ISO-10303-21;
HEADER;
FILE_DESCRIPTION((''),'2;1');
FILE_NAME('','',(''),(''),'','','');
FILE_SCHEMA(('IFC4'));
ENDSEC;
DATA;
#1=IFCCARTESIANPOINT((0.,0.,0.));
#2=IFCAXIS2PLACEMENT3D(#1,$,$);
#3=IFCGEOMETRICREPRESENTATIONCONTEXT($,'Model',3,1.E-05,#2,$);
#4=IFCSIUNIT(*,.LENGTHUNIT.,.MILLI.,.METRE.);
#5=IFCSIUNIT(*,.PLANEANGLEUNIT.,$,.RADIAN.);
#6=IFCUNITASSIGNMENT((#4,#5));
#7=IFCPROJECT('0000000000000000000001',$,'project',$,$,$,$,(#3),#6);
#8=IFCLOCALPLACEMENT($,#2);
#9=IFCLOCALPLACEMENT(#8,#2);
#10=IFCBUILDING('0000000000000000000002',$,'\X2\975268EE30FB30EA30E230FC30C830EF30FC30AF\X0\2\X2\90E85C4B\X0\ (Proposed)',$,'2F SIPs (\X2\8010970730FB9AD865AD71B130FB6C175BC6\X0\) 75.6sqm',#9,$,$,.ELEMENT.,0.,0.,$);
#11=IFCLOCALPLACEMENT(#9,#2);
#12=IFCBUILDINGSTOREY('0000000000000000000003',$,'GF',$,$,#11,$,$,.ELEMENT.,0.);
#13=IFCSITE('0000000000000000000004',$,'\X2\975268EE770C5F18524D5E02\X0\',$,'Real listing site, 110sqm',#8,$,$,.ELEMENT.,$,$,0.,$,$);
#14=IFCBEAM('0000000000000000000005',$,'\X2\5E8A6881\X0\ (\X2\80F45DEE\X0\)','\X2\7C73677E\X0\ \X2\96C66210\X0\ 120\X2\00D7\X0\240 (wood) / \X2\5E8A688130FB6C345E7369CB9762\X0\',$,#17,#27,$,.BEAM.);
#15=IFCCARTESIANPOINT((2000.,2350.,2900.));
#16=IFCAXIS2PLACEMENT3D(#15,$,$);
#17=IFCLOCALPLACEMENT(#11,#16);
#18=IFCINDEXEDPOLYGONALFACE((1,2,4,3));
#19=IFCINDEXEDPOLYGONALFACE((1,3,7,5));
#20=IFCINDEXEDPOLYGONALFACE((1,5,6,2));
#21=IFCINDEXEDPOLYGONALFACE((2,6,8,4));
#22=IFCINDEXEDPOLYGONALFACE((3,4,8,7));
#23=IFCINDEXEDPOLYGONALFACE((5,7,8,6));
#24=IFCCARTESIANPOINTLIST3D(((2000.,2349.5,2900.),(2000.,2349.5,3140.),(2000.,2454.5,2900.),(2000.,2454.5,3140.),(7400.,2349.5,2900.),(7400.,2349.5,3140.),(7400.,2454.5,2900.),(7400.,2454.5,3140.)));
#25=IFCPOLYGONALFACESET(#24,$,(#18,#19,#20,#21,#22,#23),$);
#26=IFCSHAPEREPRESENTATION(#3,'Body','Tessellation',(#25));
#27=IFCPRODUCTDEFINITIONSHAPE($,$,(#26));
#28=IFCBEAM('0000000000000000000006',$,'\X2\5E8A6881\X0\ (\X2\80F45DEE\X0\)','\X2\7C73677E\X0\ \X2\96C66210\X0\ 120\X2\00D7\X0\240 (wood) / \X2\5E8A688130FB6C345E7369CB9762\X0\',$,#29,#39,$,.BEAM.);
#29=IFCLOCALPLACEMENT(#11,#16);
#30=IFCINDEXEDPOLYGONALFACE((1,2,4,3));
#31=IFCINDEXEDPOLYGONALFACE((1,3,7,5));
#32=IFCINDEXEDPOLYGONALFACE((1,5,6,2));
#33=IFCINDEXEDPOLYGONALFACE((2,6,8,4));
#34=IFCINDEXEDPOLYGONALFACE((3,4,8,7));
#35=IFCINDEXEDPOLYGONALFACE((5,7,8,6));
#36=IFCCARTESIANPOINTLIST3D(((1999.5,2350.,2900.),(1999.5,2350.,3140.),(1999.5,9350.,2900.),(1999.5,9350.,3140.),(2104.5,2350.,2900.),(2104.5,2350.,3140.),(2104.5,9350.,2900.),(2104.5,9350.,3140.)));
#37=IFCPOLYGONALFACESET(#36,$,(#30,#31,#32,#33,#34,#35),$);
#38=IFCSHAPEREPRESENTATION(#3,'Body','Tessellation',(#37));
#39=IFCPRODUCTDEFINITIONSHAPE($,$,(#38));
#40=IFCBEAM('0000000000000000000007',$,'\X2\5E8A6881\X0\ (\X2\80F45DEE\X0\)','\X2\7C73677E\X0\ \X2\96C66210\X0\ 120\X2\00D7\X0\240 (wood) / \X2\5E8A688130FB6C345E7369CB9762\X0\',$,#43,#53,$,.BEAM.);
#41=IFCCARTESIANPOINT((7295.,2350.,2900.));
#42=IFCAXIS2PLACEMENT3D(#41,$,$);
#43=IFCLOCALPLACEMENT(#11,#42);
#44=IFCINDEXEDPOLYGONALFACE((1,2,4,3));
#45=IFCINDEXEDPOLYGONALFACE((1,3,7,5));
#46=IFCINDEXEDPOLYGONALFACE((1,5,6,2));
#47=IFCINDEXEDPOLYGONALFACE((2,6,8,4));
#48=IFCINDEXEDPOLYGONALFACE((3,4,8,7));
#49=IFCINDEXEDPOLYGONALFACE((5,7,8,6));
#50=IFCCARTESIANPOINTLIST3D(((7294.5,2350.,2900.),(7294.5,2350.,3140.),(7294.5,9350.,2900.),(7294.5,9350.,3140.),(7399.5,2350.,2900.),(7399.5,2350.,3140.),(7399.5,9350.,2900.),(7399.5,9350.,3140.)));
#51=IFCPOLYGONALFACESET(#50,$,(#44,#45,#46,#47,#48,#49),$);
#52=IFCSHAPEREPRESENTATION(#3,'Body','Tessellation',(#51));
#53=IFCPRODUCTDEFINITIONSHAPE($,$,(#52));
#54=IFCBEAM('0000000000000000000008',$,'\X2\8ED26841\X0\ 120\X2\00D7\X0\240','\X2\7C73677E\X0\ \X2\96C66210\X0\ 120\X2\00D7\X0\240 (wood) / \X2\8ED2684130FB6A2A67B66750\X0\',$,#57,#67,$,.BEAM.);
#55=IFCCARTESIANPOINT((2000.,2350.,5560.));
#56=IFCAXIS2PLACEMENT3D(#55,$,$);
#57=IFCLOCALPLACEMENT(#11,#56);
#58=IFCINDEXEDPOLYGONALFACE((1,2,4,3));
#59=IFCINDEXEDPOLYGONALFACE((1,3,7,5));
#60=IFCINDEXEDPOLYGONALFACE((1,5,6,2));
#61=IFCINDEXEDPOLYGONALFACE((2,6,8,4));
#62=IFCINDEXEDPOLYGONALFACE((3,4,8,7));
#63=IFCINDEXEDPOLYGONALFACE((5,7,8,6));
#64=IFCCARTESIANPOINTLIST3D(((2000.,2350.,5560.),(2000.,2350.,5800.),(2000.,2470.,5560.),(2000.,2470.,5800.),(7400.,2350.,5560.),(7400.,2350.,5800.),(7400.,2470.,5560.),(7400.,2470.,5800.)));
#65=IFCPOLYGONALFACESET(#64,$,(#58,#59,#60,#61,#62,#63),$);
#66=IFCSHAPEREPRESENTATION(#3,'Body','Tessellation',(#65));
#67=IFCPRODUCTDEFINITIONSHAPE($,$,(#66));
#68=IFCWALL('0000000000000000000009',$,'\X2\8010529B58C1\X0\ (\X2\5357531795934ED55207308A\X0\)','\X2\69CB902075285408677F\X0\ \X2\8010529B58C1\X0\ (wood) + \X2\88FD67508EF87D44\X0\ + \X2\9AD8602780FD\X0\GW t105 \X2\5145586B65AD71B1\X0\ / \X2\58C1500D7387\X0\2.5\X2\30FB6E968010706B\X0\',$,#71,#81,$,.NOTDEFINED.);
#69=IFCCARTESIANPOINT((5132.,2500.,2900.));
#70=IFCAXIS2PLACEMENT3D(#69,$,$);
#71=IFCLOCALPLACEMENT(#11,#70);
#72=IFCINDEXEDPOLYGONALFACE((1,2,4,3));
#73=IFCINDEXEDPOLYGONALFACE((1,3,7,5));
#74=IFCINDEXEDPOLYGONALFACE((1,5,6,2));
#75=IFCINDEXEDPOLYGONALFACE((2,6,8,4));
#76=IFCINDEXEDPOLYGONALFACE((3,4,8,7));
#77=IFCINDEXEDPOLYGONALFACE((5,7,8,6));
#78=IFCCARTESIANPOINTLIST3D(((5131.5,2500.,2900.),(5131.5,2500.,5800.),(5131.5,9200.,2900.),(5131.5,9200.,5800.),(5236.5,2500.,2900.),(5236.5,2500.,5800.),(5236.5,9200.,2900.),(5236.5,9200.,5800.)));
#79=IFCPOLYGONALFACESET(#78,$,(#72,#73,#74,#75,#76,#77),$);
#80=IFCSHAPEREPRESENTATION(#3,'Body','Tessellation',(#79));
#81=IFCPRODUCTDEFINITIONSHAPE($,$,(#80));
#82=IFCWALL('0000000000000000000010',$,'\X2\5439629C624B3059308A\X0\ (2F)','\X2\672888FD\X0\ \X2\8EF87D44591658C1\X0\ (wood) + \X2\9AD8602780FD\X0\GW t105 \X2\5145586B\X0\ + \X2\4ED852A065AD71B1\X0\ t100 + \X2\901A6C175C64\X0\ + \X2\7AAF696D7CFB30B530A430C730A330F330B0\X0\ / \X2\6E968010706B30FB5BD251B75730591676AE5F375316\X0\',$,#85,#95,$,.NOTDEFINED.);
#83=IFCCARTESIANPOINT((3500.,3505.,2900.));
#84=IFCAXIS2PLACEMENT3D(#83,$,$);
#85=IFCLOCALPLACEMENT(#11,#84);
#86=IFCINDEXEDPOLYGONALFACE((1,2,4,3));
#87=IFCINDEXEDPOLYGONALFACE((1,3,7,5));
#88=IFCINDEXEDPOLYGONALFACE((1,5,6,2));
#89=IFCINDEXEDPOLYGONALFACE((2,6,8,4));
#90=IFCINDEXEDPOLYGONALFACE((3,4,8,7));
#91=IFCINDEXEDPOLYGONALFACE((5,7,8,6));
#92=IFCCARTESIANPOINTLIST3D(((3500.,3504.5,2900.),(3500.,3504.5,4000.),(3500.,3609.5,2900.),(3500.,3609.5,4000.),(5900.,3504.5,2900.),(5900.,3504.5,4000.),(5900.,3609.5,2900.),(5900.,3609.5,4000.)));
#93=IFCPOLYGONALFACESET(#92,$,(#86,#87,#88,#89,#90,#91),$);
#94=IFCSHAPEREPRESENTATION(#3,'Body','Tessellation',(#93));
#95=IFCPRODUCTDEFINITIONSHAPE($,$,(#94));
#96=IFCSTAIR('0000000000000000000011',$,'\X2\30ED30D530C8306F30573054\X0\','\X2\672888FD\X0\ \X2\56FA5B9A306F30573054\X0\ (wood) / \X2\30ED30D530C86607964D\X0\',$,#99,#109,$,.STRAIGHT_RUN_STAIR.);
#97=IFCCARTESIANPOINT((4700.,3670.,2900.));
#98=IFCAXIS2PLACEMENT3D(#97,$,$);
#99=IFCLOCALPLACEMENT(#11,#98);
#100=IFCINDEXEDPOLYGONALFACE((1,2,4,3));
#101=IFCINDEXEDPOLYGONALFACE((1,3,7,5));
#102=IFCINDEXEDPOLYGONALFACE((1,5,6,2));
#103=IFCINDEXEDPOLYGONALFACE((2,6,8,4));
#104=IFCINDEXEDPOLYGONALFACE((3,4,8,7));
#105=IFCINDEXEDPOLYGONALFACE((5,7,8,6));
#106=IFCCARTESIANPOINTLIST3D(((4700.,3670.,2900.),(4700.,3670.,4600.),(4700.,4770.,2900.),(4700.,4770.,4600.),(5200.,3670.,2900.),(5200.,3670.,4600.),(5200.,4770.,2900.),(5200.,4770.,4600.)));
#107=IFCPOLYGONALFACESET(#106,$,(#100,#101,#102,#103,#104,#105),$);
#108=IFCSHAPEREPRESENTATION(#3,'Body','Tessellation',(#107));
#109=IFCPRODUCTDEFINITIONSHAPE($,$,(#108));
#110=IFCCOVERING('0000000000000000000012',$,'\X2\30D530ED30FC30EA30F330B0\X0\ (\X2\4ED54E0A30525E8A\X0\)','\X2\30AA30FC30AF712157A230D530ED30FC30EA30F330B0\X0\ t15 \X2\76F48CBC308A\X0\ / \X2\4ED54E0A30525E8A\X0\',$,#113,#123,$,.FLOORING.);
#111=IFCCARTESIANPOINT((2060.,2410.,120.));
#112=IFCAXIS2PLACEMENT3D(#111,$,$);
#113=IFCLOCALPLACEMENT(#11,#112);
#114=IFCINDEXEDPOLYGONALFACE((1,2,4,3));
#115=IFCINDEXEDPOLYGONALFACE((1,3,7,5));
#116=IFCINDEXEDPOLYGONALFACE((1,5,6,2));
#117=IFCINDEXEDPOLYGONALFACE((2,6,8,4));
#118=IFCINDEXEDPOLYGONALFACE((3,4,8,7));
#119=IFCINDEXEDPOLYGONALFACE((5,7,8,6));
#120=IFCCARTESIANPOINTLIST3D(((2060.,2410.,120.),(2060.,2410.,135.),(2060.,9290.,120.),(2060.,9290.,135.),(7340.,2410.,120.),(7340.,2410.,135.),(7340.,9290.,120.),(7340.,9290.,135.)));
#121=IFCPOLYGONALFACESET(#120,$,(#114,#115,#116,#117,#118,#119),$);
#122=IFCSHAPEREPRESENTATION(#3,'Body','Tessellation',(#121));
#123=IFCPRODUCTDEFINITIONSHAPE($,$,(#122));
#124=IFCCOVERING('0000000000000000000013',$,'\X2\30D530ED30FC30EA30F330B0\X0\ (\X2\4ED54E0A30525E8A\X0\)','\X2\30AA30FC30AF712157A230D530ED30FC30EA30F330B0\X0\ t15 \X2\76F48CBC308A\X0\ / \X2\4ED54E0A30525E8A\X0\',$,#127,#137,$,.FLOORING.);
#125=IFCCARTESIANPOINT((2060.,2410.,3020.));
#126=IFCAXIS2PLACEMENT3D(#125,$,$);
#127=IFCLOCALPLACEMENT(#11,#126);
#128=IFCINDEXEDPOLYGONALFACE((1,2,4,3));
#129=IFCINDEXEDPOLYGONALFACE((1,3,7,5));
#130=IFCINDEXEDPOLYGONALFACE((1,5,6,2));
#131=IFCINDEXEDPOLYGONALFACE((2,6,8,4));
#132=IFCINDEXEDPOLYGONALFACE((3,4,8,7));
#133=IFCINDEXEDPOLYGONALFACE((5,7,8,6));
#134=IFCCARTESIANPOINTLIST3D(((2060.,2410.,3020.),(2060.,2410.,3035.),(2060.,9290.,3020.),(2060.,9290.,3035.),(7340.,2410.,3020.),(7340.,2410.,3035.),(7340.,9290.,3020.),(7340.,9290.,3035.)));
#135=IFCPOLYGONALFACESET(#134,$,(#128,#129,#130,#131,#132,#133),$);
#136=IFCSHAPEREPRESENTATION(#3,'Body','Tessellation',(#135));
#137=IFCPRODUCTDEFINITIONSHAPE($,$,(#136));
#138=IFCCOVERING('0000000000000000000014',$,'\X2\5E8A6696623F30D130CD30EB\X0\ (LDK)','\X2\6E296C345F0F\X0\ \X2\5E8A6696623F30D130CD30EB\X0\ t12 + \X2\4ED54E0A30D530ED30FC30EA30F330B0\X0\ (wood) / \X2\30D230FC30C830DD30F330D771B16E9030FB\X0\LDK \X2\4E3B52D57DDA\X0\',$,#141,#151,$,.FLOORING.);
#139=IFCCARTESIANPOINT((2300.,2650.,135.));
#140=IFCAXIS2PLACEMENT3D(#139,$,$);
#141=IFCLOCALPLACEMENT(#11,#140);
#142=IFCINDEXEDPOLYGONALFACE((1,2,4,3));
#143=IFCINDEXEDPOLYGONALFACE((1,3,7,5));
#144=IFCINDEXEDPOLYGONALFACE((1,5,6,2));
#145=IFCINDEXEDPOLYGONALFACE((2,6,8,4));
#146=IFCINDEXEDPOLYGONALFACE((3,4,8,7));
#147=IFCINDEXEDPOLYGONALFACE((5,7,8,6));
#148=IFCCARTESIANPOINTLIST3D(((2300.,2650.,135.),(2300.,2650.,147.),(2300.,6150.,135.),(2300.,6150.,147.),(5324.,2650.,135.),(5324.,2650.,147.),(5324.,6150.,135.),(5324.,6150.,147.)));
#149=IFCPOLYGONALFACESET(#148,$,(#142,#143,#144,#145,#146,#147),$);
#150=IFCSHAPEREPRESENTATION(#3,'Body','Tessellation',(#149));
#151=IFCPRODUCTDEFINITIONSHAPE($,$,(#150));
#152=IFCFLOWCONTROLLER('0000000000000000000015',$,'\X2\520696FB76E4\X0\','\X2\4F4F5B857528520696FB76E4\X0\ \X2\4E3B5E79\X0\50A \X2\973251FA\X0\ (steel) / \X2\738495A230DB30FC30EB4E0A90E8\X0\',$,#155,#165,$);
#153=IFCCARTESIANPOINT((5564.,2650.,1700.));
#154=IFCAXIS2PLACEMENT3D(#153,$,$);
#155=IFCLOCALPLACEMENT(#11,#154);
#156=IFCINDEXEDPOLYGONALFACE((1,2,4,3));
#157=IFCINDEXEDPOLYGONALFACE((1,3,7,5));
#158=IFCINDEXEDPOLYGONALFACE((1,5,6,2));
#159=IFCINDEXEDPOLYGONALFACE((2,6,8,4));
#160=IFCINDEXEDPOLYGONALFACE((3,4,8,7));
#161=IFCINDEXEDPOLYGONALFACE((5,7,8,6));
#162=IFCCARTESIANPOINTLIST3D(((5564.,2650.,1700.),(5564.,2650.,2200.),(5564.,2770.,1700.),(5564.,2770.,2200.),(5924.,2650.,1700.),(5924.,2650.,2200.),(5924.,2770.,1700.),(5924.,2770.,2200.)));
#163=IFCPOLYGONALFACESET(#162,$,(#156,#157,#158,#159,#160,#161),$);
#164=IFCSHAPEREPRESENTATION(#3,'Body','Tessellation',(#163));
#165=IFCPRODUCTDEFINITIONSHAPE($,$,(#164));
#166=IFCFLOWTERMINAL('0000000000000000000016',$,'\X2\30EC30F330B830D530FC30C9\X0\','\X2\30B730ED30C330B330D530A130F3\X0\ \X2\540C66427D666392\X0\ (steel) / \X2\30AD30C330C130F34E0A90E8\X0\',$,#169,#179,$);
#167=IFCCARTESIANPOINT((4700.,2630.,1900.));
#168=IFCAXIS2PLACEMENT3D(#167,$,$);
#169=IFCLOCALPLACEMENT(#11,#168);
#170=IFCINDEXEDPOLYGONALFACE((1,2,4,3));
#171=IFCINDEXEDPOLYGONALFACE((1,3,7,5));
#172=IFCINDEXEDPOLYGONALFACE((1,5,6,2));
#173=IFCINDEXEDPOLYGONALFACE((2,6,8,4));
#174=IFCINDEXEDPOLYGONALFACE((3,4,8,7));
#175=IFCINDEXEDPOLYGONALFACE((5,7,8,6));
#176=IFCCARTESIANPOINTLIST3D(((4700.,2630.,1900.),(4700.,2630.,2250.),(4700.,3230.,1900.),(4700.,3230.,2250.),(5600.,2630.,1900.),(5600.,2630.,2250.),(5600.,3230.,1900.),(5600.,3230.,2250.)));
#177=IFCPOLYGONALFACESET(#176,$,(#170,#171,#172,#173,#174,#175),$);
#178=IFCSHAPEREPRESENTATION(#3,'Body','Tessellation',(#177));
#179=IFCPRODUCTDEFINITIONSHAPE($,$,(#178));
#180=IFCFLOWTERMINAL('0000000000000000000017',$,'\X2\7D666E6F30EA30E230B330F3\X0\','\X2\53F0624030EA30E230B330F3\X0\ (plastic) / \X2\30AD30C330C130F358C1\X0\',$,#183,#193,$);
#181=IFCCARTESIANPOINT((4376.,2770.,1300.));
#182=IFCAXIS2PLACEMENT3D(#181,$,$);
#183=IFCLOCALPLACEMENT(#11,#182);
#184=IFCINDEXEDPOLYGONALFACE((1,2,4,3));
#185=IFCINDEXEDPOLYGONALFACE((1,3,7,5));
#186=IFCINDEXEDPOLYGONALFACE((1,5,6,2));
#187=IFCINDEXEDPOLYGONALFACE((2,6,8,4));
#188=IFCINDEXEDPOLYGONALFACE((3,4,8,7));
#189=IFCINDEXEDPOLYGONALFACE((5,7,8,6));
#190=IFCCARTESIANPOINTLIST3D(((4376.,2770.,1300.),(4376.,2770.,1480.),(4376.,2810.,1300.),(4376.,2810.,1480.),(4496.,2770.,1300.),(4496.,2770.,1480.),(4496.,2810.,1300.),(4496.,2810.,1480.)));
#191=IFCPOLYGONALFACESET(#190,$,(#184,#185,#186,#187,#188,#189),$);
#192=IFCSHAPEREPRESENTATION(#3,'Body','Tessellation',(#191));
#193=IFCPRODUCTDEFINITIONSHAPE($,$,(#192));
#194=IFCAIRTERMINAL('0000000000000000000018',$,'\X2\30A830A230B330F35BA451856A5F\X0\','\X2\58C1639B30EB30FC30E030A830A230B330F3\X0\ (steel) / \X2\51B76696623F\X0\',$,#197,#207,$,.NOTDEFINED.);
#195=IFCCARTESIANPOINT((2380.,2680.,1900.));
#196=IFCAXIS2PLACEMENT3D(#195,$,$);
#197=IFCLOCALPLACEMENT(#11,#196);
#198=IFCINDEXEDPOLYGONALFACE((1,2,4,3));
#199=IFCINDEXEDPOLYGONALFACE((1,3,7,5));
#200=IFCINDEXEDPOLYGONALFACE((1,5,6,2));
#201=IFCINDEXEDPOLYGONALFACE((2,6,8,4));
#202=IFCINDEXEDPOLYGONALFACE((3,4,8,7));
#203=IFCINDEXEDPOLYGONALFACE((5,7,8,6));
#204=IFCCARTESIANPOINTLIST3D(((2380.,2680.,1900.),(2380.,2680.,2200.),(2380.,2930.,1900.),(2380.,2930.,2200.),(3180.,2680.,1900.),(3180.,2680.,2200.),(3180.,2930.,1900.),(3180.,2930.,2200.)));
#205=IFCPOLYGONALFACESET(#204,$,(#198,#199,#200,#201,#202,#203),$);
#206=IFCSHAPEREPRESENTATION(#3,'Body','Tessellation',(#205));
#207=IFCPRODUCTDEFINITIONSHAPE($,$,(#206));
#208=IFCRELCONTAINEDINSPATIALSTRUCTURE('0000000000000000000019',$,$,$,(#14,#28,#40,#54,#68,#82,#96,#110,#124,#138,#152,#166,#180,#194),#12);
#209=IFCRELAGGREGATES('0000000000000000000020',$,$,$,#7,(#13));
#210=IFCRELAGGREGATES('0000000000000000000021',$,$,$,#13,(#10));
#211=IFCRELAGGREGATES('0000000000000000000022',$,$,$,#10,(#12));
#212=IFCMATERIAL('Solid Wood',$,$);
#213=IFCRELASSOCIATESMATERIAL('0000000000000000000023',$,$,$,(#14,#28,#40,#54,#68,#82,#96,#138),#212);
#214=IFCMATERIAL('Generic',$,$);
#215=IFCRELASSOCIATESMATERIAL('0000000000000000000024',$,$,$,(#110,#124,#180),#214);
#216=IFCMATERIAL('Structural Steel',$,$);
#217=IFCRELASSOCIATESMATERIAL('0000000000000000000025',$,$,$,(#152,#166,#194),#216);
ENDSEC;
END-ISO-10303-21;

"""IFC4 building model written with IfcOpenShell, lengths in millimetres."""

from ifc_helpers import new_model, si_unit, frame, frame_2d, origin, place, context, project, spatial, rectangle, extrude, material, element, save


model = new_model("IFC4")

# Units and contexts
model_context = context("Model", 3, precision=1e-05, world=origin())
ifc_project = project(units=[si_unit("LENGTHUNIT", "METRE", prefix="MILLI"), si_unit("PLANEANGLEUNIT", "RADIAN")], contexts=[model_context])

# Site, building, storey
site_placement = place(None, origin())
site = spatial("IfcSite", under=ifc_project, at=site_placement, Name="青森県弘前市", ObjectType="Real listing site, 110sqm", CompositionType="ELEMENT", RefElevation=0.0)
building_placement = place(site_placement, origin())
building = spatial("IfcBuilding", under=site, at=building_placement, Name="青森・リモートワーク2部屋 (Proposed)", ObjectType="2F SIPs (耐震・高断熱・気密) 75.6sqm", CompositionType="ELEMENT", ElevationOfRefHeight=0.0, ElevationOfTerrain=0.0)
storey_placement = place(building_placement, origin())
storey = spatial("IfcBuildingStorey", under=building, at=storey_placement, Name="GF", CompositionType="ELEMENT", Elevation=0.0)

# Beams
ifc_material_1 = material(Name="Solid Wood")
beam_1_placement = place(storey_placement, frame((2000.0, 2350.0, 2900.0)))
element("IfcBeam", 1, at=beam_1_placement, inside=storey, material=ifc_material_1, Name="床梁 (胴差)", Description="米松 集成 120×240 (wood) / 床梁・水平構面", PredefinedType="BEAM", context=model_context, shape_type="SweptSolid", body=[
    extrude(rectangle(XDim=5400.0, YDim=105.0, at=frame_2d((2700.0, 52.0))), frame((2000.0, 2350.0, 2900.0)), (0.0, 0.0, 1.0), 240.0),
])
beam_2_placement = place(storey_placement, frame((2000.0, 2350.0, 2900.0)))
element("IfcBeam", 2, at=beam_2_placement, inside=storey, material=ifc_material_1, Name="床梁 (胴差)", Description="米松 集成 120×240 (wood) / 床梁・水平構面", PredefinedType="BEAM", context=model_context, shape_type="SweptSolid", body=[
    extrude(rectangle(XDim=105.0, YDim=7000.0, at=frame_2d((52.0, 3500.0))), frame((2000.0, 2350.0, 2900.0)), (0.0, 0.0, 1.0), 240.0),
])
beam_3_placement = place(storey_placement, frame((7295.0, 2350.0, 2900.0)))
element("IfcBeam", 3, at=beam_3_placement, inside=storey, material=ifc_material_1, Name="床梁 (胴差)", Description="米松 集成 120×240 (wood) / 床梁・水平構面", PredefinedType="BEAM", context=model_context, shape_type="SweptSolid", body=[
    extrude(rectangle(XDim=105.0, YDim=7000.0, at=frame_2d((52.0, 3500.0))), frame((7295.0, 2350.0, 2900.0)), (0.0, 0.0, 1.0), 240.0),
])
beam_4_placement = place(storey_placement, frame((2000.0, 2350.0, 5560.0)))
element("IfcBeam", 4, at=beam_4_placement, inside=storey, material=ifc_material_1, Name="軒桁 120×240", Description="米松 集成 120×240 (wood) / 軒桁・横架材", PredefinedType="BEAM", context=model_context, shape_type="SweptSolid", body=[
    extrude(rectangle(XDim=5400.0, YDim=120.0, at=frame_2d((2700.0, 60.0))), frame((2000.0, 2350.0, 5560.0)), (0.0, 0.0, 1.0), 240.0),
])

# Walls
wall_1_placement = place(storey_placement, frame((5132.0, 2500.0, 2900.0)))
element("IfcWall", 5, at=wall_1_placement, inside=storey, material=ifc_material_1, Name="耐力壁 (南北間仕切り)", Description="構造用合板 耐力壁 (wood) + 製材軸組 + 高性能GW t105 充填断熱 / 壁倍率2.5・準耐火", PredefinedType="NOTDEFINED", context=model_context, shape_type="SweptSolid", body=[
    extrude(rectangle(XDim=105.0, YDim=6700.0, at=frame_2d((52.0, 3350.0))), frame((5132.0, 2500.0, 2900.0)), (0.0, 0.0, 1.0), 2900.0),
])
wall_2_placement = place(storey_placement, frame((3500.0, 3505.0, 2900.0)))
element("IfcWall", 6, at=wall_2_placement, inside=storey, material=ifc_material_1, Name="吹抜手すり (2F)", Description="木製 軸組外壁 (wood) + 高性能GW t105 充填 + 付加断熱 t100 + 通気層 + 窯業系サイディング / 準耐火・寒冷地外皮強化", PredefinedType="NOTDEFINED", context=model_context, shape_type="SweptSolid", body=[
    extrude(rectangle(XDim=2400.0, YDim=105.0, at=frame_2d((1200.0, 52.0))), frame((3500.0, 3505.0, 2900.0)), (0.0, 0.0, 1.0), 1100.0),
])

# Stair
stair_1_placement = place(storey_placement, frame((4700.0, 3670.0, 2900.0)))
element("IfcStair", 7, at=stair_1_placement, inside=storey, material=ifc_material_1, Name="ロフトはしご", Description="木製 固定はしご (wood) / ロフト昇降", PredefinedType="STRAIGHT_RUN_STAIR", context=model_context, shape_type="SweptSolid", body=[
    extrude(rectangle(XDim=500.0, YDim=1100.0, at=frame_2d((250.0, 550.0))), frame((4700.0, 3670.0, 2900.0)), (0.0, 0.0, 1.0), 1700.0),
])

# Coverings
ifc_material_2 = material(Name="Generic")
covering_1_placement = place(storey_placement, frame((2060.0, 2410.0, 120.0)))
element("IfcCovering", 8, at=covering_1_placement, inside=storey, material=ifc_material_2, Name="フローリング (仕上げ床)", Description="オーク無垢フローリング t15 直貼り / 仕上げ床", PredefinedType="FLOORING", context=model_context, shape_type="SweptSolid", body=[
    extrude(rectangle(XDim=5280.0, YDim=6880.0, at=frame_2d((2640.0, 3440.0))), frame((2060.0, 2410.0, 120.0)), (0.0, 0.0, 1.0), 15.0),
])
covering_2_placement = place(storey_placement, frame((2060.0, 2410.0, 3020.0)))
element("IfcCovering", 9, at=covering_2_placement, inside=storey, material=ifc_material_2, Name="フローリング (仕上げ床)", Description="オーク無垢フローリング t15 直貼り / 仕上げ床", PredefinedType="FLOORING", context=model_context, shape_type="SweptSolid", body=[
    extrude(rectangle(XDim=5280.0, YDim=6880.0, at=frame_2d((2640.0, 3440.0))), frame((2060.0, 2410.0, 3020.0)), (0.0, 0.0, 1.0), 15.0),
])
covering_3_placement = place(storey_placement, frame((2300.0, 2650.0, 135.0)))
element("IfcCovering", 10, at=covering_3_placement, inside=storey, material=ifc_material_1, Name="床暖房パネル (LDK)", Description="温水式 床暖房パネル t12 + 仕上フローリング (wood) / ヒートポンプ熱源・LDK 主動線", PredefinedType="FLOORING", context=model_context, shape_type="SweptSolid", body=[
    extrude(rectangle(XDim=3024.0, YDim=3500.0, at=frame_2d((1512.0, 1750.0))), frame((2300.0, 2650.0, 135.0)), (0.0, 0.0, 1.0), 12.0),
])

# Flow controller
ifc_material_3 = material(Name="Structural Steel")
flow_controller_placement = place(storey_placement, frame((5564.0, 2650.0, 1700.0)))
element("IfcFlowController", 11, at=flow_controller_placement, inside=storey, material=ifc_material_3, Name="分電盤", Description="住宅用分電盤 主幹50A 露出 (steel) / 玄関ホール上部", context=model_context, shape_type="SweptSolid", body=[
    extrude(rectangle(XDim=360.0, YDim=120.0, at=frame_2d((180.0, 60.0))), frame((5564.0, 2650.0, 1700.0)), (0.0, 0.0, 1.0), 500.0),
])

# Flow terminals
flow_terminal_1_placement = place(storey_placement, frame((4700.0, 2630.0, 1900.0)))
element("IfcFlowTerminal", 12, at=flow_terminal_1_placement, inside=storey, material=ifc_material_3, Name="レンジフード", Description="シロッコファン 同時給排 (steel) / キッチン上部", context=model_context, shape_type="SweptSolid", body=[
    extrude(rectangle(XDim=900.0, YDim=600.0, at=frame_2d((450.0, 300.0))), frame((4700.0, 2630.0, 1900.0)), (0.0, 0.0, 1.0), 350.0),
])
flow_terminal_2_placement = place(storey_placement, frame((4376.0, 2770.0, 1300.0)))
element("IfcFlowTerminal", 13, at=flow_terminal_2_placement, inside=storey, material=ifc_material_2, Name="給湯リモコン", Description="台所リモコン (plastic) / キッチン壁", context=model_context, shape_type="SweptSolid", body=[
    extrude(rectangle(XDim=120.0, YDim=40.0, at=frame_2d((60.0, 20.0))), frame((4376.0, 2770.0, 1300.0)), (0.0, 0.0, 1.0), 180.0),
])

# Air terminal
air_terminal_1_placement = place(storey_placement, frame((2380.0, 2680.0, 1900.0)))
element("IfcAirTerminal", 14, at=air_terminal_1_placement, inside=storey, material=ifc_material_3, Name="エアコン室内機", Description="壁掛ルームエアコン (steel) / 冷暖房", PredefinedType="NOTDEFINED", context=model_context, shape_type="SweptSolid", body=[
    extrude(rectangle(XDim=800.0, YDim=250.0, at=frame_2d((400.0, 125.0))), frame((2380.0, 2680.0, 1900.0)), (0.0, 0.0, 1.0), 300.0),
])

save(model, "model.ifc")
